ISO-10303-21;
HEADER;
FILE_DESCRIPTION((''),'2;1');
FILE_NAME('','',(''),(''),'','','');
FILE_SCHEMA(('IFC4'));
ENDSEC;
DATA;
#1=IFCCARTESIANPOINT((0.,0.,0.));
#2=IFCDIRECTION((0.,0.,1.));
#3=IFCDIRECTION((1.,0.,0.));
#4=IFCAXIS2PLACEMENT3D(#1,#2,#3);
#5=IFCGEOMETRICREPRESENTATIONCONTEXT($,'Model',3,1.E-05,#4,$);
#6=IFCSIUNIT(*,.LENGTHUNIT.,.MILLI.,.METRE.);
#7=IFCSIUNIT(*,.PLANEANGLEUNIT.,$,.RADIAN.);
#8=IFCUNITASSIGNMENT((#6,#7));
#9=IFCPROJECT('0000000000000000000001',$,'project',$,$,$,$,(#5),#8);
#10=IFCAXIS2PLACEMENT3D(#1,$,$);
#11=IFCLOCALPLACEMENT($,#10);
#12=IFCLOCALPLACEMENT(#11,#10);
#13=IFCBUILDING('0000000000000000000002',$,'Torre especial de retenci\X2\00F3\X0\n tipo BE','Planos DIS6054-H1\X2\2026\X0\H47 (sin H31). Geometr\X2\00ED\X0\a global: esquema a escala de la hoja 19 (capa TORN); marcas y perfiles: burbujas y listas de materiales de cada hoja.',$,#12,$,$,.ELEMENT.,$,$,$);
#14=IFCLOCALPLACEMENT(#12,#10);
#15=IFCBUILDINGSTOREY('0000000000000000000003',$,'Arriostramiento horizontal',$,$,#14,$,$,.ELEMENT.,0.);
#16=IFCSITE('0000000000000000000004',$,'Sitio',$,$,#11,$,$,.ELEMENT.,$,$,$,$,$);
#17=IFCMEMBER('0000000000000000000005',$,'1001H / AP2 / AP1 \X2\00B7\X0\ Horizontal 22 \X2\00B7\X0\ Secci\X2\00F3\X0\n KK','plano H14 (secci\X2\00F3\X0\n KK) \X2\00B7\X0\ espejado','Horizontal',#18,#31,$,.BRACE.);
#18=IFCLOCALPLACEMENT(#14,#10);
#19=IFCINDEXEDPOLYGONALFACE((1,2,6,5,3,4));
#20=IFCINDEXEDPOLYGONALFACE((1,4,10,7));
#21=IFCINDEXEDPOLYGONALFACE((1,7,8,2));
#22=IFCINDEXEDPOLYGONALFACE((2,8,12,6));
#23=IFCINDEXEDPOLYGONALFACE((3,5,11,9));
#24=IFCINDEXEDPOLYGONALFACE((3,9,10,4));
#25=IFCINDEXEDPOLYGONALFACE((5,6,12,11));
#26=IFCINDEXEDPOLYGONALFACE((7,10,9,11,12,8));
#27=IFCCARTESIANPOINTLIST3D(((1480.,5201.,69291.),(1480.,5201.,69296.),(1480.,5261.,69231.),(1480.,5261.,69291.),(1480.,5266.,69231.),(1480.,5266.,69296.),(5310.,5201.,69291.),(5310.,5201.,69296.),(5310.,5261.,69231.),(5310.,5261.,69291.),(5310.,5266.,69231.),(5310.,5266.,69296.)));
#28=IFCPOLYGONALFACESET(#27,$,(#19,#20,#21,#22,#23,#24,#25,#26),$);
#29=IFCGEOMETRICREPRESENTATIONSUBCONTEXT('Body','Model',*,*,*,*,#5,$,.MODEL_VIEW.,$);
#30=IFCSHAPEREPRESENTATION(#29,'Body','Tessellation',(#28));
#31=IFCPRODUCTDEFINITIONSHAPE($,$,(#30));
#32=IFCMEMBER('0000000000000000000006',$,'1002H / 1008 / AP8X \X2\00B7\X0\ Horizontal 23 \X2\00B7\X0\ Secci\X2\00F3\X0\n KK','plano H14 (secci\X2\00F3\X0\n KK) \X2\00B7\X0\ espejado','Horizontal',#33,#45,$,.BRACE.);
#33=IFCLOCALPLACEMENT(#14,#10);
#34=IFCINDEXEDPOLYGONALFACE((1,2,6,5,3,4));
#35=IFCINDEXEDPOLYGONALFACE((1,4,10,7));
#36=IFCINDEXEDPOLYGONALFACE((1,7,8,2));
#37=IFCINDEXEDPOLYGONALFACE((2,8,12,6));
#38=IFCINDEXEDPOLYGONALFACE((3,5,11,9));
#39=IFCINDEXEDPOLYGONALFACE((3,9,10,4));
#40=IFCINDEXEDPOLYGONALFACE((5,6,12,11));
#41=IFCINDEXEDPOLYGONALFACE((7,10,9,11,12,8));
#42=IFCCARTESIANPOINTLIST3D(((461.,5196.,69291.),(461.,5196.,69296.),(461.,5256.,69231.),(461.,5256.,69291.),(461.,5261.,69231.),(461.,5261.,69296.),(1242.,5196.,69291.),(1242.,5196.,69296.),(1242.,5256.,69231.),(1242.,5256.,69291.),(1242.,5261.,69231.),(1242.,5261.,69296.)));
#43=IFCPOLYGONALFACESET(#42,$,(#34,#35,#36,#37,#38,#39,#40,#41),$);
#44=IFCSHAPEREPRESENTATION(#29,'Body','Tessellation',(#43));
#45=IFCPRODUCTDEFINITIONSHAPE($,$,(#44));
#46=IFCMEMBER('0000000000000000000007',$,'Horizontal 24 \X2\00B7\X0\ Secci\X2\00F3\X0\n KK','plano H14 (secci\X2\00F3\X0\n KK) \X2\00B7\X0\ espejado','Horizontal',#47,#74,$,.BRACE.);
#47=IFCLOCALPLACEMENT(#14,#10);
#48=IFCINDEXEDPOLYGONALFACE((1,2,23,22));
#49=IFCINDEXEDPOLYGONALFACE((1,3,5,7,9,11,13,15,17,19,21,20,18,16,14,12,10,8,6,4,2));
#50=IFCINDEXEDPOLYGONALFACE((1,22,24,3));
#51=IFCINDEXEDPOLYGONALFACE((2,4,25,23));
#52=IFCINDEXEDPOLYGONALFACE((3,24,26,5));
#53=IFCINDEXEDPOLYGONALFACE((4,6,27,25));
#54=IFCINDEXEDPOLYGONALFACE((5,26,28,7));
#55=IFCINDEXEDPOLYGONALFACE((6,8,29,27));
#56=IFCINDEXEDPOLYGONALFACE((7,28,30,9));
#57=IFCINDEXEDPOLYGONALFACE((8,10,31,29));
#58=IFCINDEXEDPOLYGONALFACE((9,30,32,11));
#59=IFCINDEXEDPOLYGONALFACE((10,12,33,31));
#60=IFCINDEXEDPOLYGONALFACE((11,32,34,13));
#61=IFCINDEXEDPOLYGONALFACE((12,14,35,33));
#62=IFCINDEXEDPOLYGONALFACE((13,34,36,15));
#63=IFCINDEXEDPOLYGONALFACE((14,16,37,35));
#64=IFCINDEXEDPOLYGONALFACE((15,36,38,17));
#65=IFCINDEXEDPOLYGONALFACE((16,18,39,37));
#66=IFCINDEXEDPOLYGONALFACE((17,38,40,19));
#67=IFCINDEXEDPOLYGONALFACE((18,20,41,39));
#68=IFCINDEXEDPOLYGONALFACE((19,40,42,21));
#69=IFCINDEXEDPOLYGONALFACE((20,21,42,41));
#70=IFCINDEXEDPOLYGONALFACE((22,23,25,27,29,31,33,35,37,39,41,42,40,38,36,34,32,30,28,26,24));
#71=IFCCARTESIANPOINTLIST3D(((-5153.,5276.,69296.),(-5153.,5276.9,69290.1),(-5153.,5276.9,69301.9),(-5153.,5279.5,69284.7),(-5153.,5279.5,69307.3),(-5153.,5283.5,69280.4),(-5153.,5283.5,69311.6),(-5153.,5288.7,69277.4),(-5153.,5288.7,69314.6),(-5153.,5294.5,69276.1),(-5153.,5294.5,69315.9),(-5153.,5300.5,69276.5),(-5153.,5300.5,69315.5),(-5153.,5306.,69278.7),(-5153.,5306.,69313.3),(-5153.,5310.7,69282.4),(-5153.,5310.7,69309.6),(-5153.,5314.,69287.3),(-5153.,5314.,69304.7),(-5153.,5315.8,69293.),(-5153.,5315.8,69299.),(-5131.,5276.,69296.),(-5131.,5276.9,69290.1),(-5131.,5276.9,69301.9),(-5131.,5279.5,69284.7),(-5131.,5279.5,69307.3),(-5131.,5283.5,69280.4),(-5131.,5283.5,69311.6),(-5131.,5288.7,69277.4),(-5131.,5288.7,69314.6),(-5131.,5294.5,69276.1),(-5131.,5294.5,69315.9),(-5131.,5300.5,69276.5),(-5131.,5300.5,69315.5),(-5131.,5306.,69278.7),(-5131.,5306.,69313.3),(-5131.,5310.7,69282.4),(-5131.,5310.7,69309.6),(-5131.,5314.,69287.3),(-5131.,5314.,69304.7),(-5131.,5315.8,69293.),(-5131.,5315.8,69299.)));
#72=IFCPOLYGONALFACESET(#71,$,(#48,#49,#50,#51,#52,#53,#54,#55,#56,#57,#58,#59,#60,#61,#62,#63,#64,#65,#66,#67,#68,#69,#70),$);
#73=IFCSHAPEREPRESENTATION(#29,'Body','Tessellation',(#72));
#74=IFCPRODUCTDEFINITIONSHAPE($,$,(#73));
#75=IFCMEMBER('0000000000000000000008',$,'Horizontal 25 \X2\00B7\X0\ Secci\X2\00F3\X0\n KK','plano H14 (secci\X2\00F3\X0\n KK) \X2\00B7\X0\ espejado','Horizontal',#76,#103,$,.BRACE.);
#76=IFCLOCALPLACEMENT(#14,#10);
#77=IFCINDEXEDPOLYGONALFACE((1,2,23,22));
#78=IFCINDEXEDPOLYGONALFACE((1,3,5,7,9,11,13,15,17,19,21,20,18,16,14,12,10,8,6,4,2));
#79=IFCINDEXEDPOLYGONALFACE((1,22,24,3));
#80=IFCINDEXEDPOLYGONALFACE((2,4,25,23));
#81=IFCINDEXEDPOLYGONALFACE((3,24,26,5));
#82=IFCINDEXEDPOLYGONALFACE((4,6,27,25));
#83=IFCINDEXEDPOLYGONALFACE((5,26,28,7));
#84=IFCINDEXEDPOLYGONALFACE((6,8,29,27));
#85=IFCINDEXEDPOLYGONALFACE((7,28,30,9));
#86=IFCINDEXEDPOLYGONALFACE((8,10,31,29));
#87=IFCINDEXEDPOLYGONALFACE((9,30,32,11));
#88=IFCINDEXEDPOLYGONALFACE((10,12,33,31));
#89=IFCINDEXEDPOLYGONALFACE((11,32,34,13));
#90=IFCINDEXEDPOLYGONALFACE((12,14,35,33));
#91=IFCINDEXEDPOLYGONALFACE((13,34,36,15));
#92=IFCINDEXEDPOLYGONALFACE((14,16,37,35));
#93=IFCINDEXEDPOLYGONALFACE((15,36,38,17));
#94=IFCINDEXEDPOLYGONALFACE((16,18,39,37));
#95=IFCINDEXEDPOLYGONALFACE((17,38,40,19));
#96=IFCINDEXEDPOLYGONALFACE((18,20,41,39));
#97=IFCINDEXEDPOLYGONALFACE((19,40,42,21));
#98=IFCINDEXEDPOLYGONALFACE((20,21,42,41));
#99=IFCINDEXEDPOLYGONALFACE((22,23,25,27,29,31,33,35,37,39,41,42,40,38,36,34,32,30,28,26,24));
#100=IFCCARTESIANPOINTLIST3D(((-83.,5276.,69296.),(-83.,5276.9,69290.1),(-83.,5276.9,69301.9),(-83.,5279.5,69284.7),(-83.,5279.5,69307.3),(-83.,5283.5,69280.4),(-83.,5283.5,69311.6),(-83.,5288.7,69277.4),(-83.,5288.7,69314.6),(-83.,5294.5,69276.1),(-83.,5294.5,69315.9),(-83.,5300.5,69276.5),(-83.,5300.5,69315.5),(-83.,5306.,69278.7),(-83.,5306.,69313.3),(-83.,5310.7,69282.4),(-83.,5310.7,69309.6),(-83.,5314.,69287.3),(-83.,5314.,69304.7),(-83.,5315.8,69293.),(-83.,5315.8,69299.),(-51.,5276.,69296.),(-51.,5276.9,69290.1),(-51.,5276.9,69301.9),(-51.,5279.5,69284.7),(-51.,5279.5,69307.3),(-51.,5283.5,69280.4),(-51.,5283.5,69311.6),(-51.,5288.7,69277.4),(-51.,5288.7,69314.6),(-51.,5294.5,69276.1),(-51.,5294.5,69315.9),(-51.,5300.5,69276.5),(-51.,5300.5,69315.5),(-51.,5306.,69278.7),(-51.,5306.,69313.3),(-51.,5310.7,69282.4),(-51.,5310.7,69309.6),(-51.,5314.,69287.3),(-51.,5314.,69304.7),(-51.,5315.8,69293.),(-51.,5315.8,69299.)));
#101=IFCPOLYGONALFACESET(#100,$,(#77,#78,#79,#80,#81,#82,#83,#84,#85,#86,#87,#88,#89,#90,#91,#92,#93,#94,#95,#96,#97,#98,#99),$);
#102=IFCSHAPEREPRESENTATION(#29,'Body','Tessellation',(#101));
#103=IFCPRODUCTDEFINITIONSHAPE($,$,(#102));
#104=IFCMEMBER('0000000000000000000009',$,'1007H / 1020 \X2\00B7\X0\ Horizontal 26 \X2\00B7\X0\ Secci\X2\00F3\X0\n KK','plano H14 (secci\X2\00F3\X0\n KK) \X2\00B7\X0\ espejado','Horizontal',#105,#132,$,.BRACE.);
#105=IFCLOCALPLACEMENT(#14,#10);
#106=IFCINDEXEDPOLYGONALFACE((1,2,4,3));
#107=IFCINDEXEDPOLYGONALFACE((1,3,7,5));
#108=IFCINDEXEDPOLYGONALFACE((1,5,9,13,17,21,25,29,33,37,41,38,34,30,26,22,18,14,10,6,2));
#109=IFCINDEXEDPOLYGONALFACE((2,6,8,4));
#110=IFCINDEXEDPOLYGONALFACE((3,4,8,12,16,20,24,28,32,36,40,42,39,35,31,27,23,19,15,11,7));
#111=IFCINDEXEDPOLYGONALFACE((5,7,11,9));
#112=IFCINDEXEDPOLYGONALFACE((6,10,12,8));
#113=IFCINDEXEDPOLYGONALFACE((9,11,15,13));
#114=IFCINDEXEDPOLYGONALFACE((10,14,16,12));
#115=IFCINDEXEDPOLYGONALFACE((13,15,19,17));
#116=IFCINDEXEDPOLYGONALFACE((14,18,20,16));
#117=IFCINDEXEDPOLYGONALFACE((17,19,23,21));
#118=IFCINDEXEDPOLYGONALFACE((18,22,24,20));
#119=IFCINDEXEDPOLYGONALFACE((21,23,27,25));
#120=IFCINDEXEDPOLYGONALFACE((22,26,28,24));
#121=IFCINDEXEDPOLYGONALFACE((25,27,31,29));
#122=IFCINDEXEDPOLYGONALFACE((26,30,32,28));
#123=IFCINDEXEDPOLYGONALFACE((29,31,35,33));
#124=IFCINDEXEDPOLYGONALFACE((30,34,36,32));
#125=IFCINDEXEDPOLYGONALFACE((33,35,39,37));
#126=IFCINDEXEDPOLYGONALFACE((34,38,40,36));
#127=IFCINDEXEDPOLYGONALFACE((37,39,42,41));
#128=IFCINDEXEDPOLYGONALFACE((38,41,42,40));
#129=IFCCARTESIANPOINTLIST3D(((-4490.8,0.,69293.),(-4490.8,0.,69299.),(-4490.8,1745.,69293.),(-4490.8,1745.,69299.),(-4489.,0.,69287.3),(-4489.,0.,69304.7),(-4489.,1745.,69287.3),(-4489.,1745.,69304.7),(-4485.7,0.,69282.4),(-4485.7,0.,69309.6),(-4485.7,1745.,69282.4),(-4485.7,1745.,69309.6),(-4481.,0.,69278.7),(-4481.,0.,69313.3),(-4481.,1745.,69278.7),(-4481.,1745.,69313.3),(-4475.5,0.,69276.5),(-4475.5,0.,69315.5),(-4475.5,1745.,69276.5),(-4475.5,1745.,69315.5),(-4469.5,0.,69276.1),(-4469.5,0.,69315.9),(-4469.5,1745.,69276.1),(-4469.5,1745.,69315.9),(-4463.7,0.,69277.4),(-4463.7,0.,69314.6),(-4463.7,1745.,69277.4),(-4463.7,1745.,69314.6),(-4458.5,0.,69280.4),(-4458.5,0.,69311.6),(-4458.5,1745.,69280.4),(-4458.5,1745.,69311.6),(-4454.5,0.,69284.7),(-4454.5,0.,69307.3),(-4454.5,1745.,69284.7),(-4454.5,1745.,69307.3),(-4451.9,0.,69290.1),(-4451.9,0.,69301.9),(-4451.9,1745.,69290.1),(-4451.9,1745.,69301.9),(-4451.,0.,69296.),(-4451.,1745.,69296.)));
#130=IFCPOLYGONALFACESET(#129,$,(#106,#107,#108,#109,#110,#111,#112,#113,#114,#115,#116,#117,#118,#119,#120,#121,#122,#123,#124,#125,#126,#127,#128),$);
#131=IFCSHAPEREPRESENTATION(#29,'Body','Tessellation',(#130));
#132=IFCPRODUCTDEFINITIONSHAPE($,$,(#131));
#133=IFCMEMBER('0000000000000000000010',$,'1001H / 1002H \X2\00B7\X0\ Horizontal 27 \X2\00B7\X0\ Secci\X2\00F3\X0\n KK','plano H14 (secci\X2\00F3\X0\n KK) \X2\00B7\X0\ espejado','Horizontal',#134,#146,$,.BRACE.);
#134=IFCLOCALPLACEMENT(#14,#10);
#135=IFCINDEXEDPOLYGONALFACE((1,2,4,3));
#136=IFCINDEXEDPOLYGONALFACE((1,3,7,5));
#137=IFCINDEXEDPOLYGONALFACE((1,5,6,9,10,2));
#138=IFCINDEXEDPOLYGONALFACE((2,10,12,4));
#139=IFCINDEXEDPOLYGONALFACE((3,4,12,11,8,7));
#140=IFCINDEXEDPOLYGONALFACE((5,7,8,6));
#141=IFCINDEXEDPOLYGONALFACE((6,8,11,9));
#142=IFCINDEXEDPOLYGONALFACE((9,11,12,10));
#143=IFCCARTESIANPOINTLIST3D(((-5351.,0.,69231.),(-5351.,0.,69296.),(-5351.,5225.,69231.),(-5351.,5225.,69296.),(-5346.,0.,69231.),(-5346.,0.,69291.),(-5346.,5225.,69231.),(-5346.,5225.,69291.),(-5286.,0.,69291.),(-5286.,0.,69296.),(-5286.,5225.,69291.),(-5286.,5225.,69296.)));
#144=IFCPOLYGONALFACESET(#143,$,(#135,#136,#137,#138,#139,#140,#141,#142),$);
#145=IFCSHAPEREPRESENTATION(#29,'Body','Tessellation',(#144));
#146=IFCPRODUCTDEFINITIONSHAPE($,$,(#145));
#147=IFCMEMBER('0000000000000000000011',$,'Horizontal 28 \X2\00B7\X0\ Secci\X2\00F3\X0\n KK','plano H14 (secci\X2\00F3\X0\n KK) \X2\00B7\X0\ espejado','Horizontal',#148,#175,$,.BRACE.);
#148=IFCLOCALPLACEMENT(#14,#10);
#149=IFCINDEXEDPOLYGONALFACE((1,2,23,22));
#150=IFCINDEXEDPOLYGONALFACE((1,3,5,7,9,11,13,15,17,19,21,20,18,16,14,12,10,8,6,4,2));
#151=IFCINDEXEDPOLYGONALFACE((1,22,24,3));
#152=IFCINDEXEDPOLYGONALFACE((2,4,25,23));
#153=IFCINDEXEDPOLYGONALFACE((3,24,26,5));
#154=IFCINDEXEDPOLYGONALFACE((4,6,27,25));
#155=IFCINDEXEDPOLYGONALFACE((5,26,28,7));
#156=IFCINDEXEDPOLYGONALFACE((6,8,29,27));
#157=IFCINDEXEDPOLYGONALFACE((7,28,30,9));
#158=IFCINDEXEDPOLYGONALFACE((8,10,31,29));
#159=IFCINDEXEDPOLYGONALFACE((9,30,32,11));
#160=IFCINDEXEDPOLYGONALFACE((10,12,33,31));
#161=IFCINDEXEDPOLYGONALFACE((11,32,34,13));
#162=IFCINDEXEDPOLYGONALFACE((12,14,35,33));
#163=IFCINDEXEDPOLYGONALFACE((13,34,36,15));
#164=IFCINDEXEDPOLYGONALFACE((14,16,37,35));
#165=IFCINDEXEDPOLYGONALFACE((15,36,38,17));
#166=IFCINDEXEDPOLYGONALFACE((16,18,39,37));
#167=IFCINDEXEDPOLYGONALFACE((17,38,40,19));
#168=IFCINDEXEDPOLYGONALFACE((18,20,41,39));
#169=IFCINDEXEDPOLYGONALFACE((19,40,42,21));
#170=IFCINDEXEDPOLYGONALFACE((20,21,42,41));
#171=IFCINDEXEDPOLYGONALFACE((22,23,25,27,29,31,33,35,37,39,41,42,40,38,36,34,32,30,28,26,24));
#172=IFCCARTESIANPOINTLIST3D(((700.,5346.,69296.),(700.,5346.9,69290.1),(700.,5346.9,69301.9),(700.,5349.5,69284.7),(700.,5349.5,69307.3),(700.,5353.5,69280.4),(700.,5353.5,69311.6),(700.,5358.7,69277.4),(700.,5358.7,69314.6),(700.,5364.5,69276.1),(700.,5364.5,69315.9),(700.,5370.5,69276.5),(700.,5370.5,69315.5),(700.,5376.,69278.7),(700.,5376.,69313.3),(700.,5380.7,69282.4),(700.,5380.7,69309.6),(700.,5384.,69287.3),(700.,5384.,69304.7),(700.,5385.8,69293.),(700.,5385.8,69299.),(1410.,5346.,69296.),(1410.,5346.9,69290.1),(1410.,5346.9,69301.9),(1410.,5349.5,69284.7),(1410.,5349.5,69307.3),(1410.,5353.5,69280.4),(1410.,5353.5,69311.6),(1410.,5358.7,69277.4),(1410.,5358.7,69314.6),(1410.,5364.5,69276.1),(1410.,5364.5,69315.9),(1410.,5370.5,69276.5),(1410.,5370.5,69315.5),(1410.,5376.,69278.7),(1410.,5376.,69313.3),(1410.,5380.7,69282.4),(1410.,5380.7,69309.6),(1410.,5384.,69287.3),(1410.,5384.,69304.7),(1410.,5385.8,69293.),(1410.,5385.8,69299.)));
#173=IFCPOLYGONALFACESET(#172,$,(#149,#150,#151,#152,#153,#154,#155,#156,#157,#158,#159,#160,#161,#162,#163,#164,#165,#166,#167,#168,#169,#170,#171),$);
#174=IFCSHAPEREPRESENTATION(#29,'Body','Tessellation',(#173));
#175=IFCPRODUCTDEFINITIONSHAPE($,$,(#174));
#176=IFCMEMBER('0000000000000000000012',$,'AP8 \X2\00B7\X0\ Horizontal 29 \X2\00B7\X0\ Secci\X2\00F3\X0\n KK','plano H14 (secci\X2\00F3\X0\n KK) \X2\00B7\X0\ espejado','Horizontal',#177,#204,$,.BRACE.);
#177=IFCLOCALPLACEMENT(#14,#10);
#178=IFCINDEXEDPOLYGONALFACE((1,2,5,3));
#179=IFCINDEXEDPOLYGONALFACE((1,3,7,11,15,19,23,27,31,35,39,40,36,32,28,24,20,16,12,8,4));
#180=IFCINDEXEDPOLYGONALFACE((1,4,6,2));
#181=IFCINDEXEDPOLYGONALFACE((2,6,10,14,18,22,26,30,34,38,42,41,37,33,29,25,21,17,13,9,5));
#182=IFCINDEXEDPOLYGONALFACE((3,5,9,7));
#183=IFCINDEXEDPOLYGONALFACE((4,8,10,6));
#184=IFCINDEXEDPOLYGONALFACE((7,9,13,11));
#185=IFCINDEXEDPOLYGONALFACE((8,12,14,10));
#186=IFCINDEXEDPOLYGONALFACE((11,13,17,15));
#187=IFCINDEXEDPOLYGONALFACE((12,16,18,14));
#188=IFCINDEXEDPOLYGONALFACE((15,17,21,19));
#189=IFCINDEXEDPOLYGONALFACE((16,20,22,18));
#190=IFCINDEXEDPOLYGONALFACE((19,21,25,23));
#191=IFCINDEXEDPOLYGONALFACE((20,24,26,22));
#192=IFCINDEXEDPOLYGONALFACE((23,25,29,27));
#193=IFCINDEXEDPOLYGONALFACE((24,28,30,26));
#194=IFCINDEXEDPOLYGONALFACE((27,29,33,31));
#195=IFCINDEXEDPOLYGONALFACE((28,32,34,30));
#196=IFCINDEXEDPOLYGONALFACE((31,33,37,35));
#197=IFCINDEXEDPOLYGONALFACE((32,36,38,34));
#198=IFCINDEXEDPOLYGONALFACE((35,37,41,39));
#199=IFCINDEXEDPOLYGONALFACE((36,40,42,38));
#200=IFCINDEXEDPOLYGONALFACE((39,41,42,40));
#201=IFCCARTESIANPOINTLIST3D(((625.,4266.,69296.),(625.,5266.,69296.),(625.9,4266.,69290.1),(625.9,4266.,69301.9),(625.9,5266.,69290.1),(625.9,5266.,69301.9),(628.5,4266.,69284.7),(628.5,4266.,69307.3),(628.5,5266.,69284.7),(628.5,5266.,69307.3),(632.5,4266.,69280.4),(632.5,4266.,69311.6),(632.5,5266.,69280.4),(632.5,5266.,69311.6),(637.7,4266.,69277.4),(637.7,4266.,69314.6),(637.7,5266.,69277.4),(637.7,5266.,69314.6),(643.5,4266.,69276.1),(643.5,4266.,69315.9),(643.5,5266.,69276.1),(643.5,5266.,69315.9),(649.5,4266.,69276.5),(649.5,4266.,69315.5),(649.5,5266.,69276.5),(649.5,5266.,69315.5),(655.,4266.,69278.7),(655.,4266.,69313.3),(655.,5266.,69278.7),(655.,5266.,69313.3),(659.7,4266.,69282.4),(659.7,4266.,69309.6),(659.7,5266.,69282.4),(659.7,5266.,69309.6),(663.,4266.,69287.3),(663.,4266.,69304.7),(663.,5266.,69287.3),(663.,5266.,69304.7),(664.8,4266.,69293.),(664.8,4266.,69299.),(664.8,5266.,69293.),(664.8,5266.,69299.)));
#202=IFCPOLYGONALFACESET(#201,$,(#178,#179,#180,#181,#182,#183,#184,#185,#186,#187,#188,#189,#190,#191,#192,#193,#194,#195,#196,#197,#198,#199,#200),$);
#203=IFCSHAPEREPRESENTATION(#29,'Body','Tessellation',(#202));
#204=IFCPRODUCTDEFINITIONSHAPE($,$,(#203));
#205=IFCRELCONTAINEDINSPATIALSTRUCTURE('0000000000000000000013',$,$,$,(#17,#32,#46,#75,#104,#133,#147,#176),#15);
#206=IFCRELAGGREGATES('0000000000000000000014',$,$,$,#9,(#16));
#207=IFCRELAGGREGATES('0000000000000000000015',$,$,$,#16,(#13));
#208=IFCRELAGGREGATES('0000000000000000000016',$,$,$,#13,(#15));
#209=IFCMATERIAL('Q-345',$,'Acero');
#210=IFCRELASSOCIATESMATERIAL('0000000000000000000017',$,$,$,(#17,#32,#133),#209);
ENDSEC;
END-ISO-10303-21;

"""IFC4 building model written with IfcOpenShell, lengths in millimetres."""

from ifc_helpers import new_model, si_unit, frame, frame_2d, origin, origin_with_axes, place, context, subcontext, project, spatial, circle, l_section, extrude, material, element, save


model = new_model("IFC4")

# Units and contexts
model_context = context("Model", 3, precision=1e-05, world=origin_with_axes())
body_context = subcontext(model_context, "Body", "Model", "MODEL_VIEW")
ifc_project = project(units=[si_unit("LENGTHUNIT", "METRE", prefix="MILLI"), si_unit("PLANEANGLEUNIT", "RADIAN")], contexts=[model_context])

# Site, building, storey
site_placement = place(None, origin())
site = spatial("IfcSite", under=ifc_project, at=site_placement, Name="Sitio", CompositionType="ELEMENT")
building_placement = place(site_placement, origin())
building = spatial("IfcBuilding", under=site, at=building_placement, Name="Torre especial de retención tipo BE", Description="Planos DIS6054-H1…H47 (sin H31). Geometría global: esquema a escala de la hoja 19 (capa TORN); marcas y perfiles: burbujas y listas de materiales de cada hoja.", CompositionType="ELEMENT")
storey_placement = place(building_placement, origin())
storey = spatial("IfcBuildingStorey", under=building, at=storey_placement, Name="Arriostramiento horizontal", CompositionType="ELEMENT", Elevation=0.0)

# Members
ifc_material_1 = material(Name="Q-345", Category="Acero")
member_1_placement = place(storey_placement, frame((1480.0, 5266.0, 69296.0), z_axis=(1.0, 0.0, 0.0), x_axis=(0.0, -1.0, 0.0)))
element("IfcMember", 1, at=member_1_placement, inside=storey, material=ifc_material_1, Name="1001H / AP2 / AP1 · Horizontal 22 · Sección KK", Description="plano H14 (sección KK) · espejado", ObjectType="Horizontal", PredefinedType="BRACE", context=body_context, shape_type="SweptSolid", body=[
    extrude(l_section(Depth=65.0, Width=65.0, Thickness=5.0, at=frame_2d((32.5, 32.5))), None, (0.0, 0.0, 1.0), 3830.0),
])
member_2_placement = place(storey_placement, frame((461.0, 5261.0, 69296.0), z_axis=(1.0, 0.0, 0.0), x_axis=(0.0, -1.0, 0.0)))
element("IfcMember", 2, at=member_2_placement, inside=storey, material=ifc_material_1, Name="1002H / 1008 / AP8X · Horizontal 23 · Sección KK", Description="plano H14 (sección KK) · espejado", ObjectType="Horizontal", PredefinedType="BRACE", context=body_context, shape_type="SweptSolid", body=[
    extrude(l_section(Depth=65.0, Width=65.0, Thickness=5.0, at=frame_2d((32.5, 32.5))), None, (0.0, 0.0, 1.0), 781.0),
])
member_3_placement = place(storey_placement, frame((-5153.0, 5296.0, 69296.0), z_axis=(1.0, 0.0, 0.0), x_axis=(0.0, -1.0, 0.0)))
element("IfcMember", 3, at=member_3_placement, inside=storey, Name="Horizontal 24 · Sección KK", Description="plano H14 (sección KK) · espejado", ObjectType="Horizontal", PredefinedType="BRACE", context=body_context, shape_type="SweptSolid", body=[
    extrude(circle(Radius=20.0), None, (0.0, 0.0, 1.0), 22.0),
])
member_4_placement = place(storey_placement, frame((-83.0, 5296.0, 69296.0), z_axis=(1.0, 0.0, 0.0), x_axis=(0.0, -1.0, 0.0)))
element("IfcMember", 4, at=member_4_placement, inside=storey, Name="Horizontal 25 · Sección KK", Description="plano H14 (sección KK) · espejado", ObjectType="Horizontal", PredefinedType="BRACE", context=body_context, shape_type="SweptSolid", body=[
    extrude(circle(Radius=20.0), None, (0.0, 0.0, 1.0), 32.0),
])
member_5_placement = place(storey_placement, frame((-4471.0, 0.0, 69296.0), z_axis=(0.0, 1.0, 0.0), x_axis=(1.0, 0.0, 0.0)))
element("IfcMember", 5, at=member_5_placement, inside=storey, Name="1007H / 1020 · Horizontal 26 · Sección KK", Description="plano H14 (sección KK) · espejado", ObjectType="Horizontal", PredefinedType="BRACE", context=body_context, shape_type="SweptSolid", body=[
    extrude(circle(Radius=20.0), None, (0.0, 0.0, 1.0), 1745.0),
])
member_6_placement = place(storey_placement, frame((-5351.0, 0.0, 69296.0), z_axis=(0.0, 1.0, 0.0), x_axis=(1.0, 0.0, 0.0)))
element("IfcMember", 6, at=member_6_placement, inside=storey, material=ifc_material_1, Name="1001H / 1002H · Horizontal 27 · Sección KK", Description="plano H14 (sección KK) · espejado", ObjectType="Horizontal", PredefinedType="BRACE", context=body_context, shape_type="SweptSolid", body=[
    extrude(l_section(Depth=65.0, Width=65.0, Thickness=5.0, at=frame_2d((32.5, 32.5))), None, (0.0, 0.0, 1.0), 5225.0),
])
member_7_placement = place(storey_placement, frame((700.0, 5366.0, 69296.0), z_axis=(1.0, 0.0, 0.0), x_axis=(0.0, -1.0, 0.0)))
element("IfcMember", 7, at=member_7_placement, inside=storey, Name="Horizontal 28 · Sección KK", Description="plano H14 (sección KK) · espejado", ObjectType="Horizontal", PredefinedType="BRACE", context=body_context, shape_type="SweptSolid", body=[
    extrude(circle(Radius=20.0), None, (0.0, 0.0, 1.0), 710.0),
])
for number, where, z_axis, x_axis, name in (
    (8, (645.0, 4266.0, 69296.0), (0.0, 1.0, 0.0), (-1.0, 0.0, 0.0), "AP8 · Horizontal 29 · Sección KK"),
):
    element("IfcMember", number, at=place(storey_placement, frame(where, z_axis=z_axis, x_axis=x_axis)), inside=storey, Name=name, Description="plano H14 (sección KK) · espejado", ObjectType="Horizontal", PredefinedType="BRACE", context=body_context, shape_type="SweptSolid", body=[
        extrude(circle(Radius=20.0), None, (0.0, 0.0, 1.0), 1000.0),
    ])

save(model, "model.ifc")
